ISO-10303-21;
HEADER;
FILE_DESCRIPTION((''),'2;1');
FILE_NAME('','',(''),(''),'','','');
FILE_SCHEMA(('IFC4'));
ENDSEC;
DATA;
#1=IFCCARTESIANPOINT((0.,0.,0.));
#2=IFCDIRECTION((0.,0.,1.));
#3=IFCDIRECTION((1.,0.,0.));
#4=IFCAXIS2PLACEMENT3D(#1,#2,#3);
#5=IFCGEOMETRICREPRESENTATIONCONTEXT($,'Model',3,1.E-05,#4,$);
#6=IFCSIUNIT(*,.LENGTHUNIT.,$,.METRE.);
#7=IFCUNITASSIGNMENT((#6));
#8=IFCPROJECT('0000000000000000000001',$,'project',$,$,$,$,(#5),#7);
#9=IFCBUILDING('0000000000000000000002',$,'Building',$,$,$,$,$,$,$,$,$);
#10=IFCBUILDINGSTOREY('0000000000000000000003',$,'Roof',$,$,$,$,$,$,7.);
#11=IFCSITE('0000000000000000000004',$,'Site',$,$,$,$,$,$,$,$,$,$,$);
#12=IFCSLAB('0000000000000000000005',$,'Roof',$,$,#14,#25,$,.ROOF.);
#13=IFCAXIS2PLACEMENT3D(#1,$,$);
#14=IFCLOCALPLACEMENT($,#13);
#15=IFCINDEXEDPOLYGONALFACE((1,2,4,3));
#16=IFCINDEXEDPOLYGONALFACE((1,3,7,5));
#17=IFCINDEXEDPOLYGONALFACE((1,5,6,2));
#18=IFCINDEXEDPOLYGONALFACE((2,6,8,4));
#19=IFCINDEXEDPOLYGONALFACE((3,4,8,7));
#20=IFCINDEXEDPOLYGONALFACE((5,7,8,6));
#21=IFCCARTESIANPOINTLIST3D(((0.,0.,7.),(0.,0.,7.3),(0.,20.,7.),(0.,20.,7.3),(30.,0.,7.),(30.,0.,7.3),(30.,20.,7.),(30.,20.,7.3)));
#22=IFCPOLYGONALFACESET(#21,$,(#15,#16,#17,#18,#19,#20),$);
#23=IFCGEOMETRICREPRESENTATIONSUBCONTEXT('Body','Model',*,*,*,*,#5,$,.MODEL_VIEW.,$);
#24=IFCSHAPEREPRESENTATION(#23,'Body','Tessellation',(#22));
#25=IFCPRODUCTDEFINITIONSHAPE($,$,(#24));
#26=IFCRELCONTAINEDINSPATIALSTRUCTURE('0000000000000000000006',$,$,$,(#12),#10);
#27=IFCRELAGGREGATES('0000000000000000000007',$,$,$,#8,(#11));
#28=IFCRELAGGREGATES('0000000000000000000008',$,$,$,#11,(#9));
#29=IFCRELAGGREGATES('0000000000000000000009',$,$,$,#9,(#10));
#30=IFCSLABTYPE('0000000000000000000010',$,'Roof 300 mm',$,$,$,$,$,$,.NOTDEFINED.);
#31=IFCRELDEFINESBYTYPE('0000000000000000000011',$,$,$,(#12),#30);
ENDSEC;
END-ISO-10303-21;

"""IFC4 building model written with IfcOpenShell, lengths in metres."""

from ifc_helpers import new_model, si_unit, frame, origin_with_axes, place, context, subcontext, project, spatial, indexed_curve, outline, extrude, type_object, element, save


model = new_model("IFC4")

# Units and contexts
model_context = context("Model", 3, precision=1e-05, world=origin_with_axes())
body_context = subcontext(model_context, "Body", "Model", "MODEL_VIEW")
ifc_project = project(units=[si_unit("LENGTHUNIT", "METRE")], contexts=[model_context])

# Site, building, storey
site = spatial("IfcSite", under=ifc_project, Name="Site")
building = spatial("IfcBuilding", under=site, Name="Building")
storey = spatial("IfcBuildingStorey", under=building, Name="Roof", Elevation=7.0)

# Slab
slab_type = type_object("IfcSlabType", Name="Roof 300 mm", PredefinedType="NOTDEFINED")
slab_placement = place(None, frame((0.0, 0.0, 7.0), z_axis=(0.0, 0.0, 1.0), x_axis=(1.0, 0.0, 0.0)))
element("IfcSlab", 1, at=slab_placement, inside=storey, type_object=slab_type, Name="Roof", PredefinedType="ROOF", context=body_context, shape_type="SweptSolid", body=[
    extrude(outline(indexed_curve([(0.0, 0.0), (30.0, 0.0), (30.0, 20.0), (0.0, 20.0)])), None, (0.0, 0.0, 1.0), 0.3),
])

save(model, "model.ifc")
